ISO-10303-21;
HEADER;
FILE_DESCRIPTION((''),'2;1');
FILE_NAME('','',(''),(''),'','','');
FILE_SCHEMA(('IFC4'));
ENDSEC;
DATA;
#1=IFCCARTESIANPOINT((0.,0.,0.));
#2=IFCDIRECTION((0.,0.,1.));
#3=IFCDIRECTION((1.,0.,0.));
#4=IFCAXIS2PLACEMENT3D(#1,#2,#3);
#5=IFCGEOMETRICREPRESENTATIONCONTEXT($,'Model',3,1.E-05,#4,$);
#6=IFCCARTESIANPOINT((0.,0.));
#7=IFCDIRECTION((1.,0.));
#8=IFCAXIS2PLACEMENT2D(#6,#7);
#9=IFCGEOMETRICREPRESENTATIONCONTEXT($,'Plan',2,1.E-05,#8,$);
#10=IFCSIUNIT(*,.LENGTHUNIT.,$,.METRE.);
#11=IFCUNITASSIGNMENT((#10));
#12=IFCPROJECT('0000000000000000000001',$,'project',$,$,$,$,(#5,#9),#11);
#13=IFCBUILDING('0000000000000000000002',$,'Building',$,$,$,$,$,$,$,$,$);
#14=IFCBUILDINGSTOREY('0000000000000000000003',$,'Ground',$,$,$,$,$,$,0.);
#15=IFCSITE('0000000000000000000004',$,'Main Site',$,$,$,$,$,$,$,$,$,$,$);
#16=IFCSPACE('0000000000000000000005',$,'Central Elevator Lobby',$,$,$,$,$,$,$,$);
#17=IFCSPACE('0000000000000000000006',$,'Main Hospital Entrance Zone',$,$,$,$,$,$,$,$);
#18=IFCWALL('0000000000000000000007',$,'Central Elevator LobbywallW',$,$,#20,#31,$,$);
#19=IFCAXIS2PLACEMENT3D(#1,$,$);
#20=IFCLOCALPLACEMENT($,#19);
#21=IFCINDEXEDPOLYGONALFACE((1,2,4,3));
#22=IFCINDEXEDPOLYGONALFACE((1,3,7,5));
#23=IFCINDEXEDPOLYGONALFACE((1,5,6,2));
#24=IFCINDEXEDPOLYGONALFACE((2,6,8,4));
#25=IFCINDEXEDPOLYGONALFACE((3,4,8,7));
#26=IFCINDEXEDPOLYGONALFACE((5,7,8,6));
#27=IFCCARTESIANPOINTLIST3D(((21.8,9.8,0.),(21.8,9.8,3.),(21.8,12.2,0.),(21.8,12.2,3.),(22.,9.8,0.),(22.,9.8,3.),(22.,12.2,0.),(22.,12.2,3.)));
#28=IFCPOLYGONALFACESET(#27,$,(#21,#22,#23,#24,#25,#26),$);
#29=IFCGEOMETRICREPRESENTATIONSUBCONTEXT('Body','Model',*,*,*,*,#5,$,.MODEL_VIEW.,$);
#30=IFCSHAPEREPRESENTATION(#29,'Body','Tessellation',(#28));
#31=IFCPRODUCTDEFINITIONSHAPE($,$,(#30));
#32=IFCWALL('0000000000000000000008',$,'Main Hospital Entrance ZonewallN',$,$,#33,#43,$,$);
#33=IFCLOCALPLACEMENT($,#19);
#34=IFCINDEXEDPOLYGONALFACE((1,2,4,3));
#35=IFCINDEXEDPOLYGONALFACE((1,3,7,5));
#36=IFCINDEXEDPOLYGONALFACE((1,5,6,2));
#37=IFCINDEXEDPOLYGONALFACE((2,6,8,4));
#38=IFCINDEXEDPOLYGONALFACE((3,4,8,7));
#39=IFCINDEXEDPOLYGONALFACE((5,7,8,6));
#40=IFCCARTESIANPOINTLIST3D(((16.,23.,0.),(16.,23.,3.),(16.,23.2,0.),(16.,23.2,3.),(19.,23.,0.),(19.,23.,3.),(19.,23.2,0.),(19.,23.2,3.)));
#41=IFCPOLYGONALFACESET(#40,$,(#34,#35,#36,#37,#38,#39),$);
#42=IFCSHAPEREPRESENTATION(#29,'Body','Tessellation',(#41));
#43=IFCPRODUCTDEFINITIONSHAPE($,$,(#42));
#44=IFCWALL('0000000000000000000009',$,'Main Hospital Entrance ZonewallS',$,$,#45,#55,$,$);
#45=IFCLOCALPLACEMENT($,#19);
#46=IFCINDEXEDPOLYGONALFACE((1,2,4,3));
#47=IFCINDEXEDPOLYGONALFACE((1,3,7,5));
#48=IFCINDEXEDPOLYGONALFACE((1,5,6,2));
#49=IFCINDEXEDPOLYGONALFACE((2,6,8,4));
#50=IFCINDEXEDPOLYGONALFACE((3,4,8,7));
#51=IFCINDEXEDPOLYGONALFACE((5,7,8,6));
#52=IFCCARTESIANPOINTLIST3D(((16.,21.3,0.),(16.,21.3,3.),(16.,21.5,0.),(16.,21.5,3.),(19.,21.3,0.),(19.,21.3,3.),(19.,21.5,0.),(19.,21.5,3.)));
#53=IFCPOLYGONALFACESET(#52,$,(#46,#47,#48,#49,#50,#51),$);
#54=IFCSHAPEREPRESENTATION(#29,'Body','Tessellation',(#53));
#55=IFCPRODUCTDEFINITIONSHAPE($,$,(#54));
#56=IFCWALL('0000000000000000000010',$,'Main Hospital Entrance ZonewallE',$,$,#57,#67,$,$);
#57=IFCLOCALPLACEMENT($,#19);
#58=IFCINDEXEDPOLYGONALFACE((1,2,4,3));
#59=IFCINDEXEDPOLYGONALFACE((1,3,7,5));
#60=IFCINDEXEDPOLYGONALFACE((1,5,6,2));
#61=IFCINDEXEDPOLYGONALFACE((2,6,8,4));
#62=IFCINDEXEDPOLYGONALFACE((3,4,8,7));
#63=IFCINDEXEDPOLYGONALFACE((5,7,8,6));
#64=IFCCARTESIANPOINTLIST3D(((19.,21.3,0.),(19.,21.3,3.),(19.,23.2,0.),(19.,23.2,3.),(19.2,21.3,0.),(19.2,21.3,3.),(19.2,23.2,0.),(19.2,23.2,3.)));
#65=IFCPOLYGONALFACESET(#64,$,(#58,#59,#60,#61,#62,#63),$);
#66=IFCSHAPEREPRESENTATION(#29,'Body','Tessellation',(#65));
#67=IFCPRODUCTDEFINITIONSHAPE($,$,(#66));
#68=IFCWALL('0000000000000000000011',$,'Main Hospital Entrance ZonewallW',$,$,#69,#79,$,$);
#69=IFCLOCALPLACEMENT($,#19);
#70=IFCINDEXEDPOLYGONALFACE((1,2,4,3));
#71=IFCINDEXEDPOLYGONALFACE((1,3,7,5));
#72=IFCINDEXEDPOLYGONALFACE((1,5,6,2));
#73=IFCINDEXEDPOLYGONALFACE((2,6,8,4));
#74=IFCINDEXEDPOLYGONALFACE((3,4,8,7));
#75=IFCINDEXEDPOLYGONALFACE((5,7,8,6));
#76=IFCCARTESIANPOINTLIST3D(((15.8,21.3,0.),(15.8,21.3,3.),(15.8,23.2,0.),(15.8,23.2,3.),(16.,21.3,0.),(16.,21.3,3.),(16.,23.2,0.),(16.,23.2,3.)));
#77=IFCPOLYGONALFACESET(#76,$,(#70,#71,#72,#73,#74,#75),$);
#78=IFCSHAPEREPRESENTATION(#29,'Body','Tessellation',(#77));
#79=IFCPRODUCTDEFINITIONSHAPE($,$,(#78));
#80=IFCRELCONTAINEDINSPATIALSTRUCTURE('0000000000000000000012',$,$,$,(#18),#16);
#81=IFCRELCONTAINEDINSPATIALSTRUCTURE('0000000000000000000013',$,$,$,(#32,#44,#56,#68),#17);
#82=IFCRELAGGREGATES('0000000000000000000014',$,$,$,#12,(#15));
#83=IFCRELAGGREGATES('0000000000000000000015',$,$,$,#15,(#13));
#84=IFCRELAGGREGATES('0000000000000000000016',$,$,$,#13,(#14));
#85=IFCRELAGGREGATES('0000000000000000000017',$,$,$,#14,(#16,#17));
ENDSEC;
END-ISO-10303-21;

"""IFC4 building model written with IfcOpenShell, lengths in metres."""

from ifc_helpers import new_model, si_unit, frame, origin_with_axes, origin_2d_with_axis, place, context, subcontext, project, spatial, indexed_curve, outline, extrude, element, save


model = new_model("IFC4")

# Units and contexts
model_context = context("Model", 3, precision=1e-05, world=origin_with_axes())
plan_context = context("Plan", 2, precision=1e-05, world=origin_2d_with_axis())
body_context = subcontext(model_context, "Body", "Model", "MODEL_VIEW")
ifc_project = project(units=[si_unit("LENGTHUNIT", "METRE")], contexts=[model_context, plan_context])

# Site, building, storey
site = spatial("IfcSite", under=ifc_project, Name="Main Site")
building = spatial("IfcBuilding", under=site, Name="Building")
storey = spatial("IfcBuildingStorey", under=building, Name="Ground", Elevation=0.0)

# Shared definitions
space_1 = spatial("IfcSpace", under=storey, Name="Central Elevator Lobby")

# Shared definitions
space_2 = spatial("IfcSpace", under=storey, Name="Main Hospital Entrance Zone")

# Walls
for number, where, z_axis, x_axis, name in (
    (1, (22.0, 9.8, 0.0), (0.0, 0.0, 1.0), (0.0, 1.0, 0.0), "Central Elevator LobbywallW"),
):
    element("IfcWall", number, at=place(None, frame(where, z_axis=z_axis, x_axis=x_axis)), inside=space_1, Name=name, context=body_context, shape_type="SweptSolid", body=[
        extrude(outline(indexed_curve([(0.0, 0.0), (0.0, 0.2), (2.4, 0.2), (2.4, 0.0), (0.0, 0.0)], self_intersect=False)), origin_with_axes(), (0.0, 0.0, 1.0), 3.0),
    ])
for number, where, z_axis, x_axis, name in (
    (2, (16.0, 23.0, 0.0), (0.0, 0.0, 1.0), (1.0, 0.0, 0.0), "Main Hospital Entrance ZonewallN"),
    (3, (16.0, 21.3, 0.0), (0.0, 0.0, 1.0), (1.0, 0.0, 0.0), "Main Hospital Entrance ZonewallS"),
):
    element("IfcWall", number, at=place(None, frame(where, z_axis=z_axis, x_axis=x_axis)), inside=space_2, Name=name, context=body_context, shape_type="SweptSolid", body=[
        extrude(outline(indexed_curve([(0.0, 0.0), (0.0, 0.2), (3.0, 0.2), (3.0, 0.0), (0.0, 0.0)], self_intersect=False)), origin_with_axes(), (0.0, 0.0, 1.0), 3.0),
    ])
for number, where, z_axis, x_axis, name in (
    (4, (19.2, 21.3, 0.0), (0.0, 0.0, 1.0), (0.0, 1.0, 0.0), "Main Hospital Entrance ZonewallE"),
    (5, (16.0, 21.3, 0.0), (0.0, 0.0, 1.0), (0.0, 1.0, 0.0), "Main Hospital Entrance ZonewallW"),
):
    element("IfcWall", number, at=place(None, frame(where, z_axis=z_axis, x_axis=x_axis)), inside=space_2, Name=name, context=body_context, shape_type="SweptSolid", body=[
        extrude(outline(indexed_curve([(0.0, 0.0), (0.0, 0.2), (1.9, 0.2), (1.9, 0.0), (0.0, 0.0)], self_intersect=False)), origin_with_axes(), (0.0, 0.0, 1.0), 3.0),
    ])

save(model, "model.ifc")
